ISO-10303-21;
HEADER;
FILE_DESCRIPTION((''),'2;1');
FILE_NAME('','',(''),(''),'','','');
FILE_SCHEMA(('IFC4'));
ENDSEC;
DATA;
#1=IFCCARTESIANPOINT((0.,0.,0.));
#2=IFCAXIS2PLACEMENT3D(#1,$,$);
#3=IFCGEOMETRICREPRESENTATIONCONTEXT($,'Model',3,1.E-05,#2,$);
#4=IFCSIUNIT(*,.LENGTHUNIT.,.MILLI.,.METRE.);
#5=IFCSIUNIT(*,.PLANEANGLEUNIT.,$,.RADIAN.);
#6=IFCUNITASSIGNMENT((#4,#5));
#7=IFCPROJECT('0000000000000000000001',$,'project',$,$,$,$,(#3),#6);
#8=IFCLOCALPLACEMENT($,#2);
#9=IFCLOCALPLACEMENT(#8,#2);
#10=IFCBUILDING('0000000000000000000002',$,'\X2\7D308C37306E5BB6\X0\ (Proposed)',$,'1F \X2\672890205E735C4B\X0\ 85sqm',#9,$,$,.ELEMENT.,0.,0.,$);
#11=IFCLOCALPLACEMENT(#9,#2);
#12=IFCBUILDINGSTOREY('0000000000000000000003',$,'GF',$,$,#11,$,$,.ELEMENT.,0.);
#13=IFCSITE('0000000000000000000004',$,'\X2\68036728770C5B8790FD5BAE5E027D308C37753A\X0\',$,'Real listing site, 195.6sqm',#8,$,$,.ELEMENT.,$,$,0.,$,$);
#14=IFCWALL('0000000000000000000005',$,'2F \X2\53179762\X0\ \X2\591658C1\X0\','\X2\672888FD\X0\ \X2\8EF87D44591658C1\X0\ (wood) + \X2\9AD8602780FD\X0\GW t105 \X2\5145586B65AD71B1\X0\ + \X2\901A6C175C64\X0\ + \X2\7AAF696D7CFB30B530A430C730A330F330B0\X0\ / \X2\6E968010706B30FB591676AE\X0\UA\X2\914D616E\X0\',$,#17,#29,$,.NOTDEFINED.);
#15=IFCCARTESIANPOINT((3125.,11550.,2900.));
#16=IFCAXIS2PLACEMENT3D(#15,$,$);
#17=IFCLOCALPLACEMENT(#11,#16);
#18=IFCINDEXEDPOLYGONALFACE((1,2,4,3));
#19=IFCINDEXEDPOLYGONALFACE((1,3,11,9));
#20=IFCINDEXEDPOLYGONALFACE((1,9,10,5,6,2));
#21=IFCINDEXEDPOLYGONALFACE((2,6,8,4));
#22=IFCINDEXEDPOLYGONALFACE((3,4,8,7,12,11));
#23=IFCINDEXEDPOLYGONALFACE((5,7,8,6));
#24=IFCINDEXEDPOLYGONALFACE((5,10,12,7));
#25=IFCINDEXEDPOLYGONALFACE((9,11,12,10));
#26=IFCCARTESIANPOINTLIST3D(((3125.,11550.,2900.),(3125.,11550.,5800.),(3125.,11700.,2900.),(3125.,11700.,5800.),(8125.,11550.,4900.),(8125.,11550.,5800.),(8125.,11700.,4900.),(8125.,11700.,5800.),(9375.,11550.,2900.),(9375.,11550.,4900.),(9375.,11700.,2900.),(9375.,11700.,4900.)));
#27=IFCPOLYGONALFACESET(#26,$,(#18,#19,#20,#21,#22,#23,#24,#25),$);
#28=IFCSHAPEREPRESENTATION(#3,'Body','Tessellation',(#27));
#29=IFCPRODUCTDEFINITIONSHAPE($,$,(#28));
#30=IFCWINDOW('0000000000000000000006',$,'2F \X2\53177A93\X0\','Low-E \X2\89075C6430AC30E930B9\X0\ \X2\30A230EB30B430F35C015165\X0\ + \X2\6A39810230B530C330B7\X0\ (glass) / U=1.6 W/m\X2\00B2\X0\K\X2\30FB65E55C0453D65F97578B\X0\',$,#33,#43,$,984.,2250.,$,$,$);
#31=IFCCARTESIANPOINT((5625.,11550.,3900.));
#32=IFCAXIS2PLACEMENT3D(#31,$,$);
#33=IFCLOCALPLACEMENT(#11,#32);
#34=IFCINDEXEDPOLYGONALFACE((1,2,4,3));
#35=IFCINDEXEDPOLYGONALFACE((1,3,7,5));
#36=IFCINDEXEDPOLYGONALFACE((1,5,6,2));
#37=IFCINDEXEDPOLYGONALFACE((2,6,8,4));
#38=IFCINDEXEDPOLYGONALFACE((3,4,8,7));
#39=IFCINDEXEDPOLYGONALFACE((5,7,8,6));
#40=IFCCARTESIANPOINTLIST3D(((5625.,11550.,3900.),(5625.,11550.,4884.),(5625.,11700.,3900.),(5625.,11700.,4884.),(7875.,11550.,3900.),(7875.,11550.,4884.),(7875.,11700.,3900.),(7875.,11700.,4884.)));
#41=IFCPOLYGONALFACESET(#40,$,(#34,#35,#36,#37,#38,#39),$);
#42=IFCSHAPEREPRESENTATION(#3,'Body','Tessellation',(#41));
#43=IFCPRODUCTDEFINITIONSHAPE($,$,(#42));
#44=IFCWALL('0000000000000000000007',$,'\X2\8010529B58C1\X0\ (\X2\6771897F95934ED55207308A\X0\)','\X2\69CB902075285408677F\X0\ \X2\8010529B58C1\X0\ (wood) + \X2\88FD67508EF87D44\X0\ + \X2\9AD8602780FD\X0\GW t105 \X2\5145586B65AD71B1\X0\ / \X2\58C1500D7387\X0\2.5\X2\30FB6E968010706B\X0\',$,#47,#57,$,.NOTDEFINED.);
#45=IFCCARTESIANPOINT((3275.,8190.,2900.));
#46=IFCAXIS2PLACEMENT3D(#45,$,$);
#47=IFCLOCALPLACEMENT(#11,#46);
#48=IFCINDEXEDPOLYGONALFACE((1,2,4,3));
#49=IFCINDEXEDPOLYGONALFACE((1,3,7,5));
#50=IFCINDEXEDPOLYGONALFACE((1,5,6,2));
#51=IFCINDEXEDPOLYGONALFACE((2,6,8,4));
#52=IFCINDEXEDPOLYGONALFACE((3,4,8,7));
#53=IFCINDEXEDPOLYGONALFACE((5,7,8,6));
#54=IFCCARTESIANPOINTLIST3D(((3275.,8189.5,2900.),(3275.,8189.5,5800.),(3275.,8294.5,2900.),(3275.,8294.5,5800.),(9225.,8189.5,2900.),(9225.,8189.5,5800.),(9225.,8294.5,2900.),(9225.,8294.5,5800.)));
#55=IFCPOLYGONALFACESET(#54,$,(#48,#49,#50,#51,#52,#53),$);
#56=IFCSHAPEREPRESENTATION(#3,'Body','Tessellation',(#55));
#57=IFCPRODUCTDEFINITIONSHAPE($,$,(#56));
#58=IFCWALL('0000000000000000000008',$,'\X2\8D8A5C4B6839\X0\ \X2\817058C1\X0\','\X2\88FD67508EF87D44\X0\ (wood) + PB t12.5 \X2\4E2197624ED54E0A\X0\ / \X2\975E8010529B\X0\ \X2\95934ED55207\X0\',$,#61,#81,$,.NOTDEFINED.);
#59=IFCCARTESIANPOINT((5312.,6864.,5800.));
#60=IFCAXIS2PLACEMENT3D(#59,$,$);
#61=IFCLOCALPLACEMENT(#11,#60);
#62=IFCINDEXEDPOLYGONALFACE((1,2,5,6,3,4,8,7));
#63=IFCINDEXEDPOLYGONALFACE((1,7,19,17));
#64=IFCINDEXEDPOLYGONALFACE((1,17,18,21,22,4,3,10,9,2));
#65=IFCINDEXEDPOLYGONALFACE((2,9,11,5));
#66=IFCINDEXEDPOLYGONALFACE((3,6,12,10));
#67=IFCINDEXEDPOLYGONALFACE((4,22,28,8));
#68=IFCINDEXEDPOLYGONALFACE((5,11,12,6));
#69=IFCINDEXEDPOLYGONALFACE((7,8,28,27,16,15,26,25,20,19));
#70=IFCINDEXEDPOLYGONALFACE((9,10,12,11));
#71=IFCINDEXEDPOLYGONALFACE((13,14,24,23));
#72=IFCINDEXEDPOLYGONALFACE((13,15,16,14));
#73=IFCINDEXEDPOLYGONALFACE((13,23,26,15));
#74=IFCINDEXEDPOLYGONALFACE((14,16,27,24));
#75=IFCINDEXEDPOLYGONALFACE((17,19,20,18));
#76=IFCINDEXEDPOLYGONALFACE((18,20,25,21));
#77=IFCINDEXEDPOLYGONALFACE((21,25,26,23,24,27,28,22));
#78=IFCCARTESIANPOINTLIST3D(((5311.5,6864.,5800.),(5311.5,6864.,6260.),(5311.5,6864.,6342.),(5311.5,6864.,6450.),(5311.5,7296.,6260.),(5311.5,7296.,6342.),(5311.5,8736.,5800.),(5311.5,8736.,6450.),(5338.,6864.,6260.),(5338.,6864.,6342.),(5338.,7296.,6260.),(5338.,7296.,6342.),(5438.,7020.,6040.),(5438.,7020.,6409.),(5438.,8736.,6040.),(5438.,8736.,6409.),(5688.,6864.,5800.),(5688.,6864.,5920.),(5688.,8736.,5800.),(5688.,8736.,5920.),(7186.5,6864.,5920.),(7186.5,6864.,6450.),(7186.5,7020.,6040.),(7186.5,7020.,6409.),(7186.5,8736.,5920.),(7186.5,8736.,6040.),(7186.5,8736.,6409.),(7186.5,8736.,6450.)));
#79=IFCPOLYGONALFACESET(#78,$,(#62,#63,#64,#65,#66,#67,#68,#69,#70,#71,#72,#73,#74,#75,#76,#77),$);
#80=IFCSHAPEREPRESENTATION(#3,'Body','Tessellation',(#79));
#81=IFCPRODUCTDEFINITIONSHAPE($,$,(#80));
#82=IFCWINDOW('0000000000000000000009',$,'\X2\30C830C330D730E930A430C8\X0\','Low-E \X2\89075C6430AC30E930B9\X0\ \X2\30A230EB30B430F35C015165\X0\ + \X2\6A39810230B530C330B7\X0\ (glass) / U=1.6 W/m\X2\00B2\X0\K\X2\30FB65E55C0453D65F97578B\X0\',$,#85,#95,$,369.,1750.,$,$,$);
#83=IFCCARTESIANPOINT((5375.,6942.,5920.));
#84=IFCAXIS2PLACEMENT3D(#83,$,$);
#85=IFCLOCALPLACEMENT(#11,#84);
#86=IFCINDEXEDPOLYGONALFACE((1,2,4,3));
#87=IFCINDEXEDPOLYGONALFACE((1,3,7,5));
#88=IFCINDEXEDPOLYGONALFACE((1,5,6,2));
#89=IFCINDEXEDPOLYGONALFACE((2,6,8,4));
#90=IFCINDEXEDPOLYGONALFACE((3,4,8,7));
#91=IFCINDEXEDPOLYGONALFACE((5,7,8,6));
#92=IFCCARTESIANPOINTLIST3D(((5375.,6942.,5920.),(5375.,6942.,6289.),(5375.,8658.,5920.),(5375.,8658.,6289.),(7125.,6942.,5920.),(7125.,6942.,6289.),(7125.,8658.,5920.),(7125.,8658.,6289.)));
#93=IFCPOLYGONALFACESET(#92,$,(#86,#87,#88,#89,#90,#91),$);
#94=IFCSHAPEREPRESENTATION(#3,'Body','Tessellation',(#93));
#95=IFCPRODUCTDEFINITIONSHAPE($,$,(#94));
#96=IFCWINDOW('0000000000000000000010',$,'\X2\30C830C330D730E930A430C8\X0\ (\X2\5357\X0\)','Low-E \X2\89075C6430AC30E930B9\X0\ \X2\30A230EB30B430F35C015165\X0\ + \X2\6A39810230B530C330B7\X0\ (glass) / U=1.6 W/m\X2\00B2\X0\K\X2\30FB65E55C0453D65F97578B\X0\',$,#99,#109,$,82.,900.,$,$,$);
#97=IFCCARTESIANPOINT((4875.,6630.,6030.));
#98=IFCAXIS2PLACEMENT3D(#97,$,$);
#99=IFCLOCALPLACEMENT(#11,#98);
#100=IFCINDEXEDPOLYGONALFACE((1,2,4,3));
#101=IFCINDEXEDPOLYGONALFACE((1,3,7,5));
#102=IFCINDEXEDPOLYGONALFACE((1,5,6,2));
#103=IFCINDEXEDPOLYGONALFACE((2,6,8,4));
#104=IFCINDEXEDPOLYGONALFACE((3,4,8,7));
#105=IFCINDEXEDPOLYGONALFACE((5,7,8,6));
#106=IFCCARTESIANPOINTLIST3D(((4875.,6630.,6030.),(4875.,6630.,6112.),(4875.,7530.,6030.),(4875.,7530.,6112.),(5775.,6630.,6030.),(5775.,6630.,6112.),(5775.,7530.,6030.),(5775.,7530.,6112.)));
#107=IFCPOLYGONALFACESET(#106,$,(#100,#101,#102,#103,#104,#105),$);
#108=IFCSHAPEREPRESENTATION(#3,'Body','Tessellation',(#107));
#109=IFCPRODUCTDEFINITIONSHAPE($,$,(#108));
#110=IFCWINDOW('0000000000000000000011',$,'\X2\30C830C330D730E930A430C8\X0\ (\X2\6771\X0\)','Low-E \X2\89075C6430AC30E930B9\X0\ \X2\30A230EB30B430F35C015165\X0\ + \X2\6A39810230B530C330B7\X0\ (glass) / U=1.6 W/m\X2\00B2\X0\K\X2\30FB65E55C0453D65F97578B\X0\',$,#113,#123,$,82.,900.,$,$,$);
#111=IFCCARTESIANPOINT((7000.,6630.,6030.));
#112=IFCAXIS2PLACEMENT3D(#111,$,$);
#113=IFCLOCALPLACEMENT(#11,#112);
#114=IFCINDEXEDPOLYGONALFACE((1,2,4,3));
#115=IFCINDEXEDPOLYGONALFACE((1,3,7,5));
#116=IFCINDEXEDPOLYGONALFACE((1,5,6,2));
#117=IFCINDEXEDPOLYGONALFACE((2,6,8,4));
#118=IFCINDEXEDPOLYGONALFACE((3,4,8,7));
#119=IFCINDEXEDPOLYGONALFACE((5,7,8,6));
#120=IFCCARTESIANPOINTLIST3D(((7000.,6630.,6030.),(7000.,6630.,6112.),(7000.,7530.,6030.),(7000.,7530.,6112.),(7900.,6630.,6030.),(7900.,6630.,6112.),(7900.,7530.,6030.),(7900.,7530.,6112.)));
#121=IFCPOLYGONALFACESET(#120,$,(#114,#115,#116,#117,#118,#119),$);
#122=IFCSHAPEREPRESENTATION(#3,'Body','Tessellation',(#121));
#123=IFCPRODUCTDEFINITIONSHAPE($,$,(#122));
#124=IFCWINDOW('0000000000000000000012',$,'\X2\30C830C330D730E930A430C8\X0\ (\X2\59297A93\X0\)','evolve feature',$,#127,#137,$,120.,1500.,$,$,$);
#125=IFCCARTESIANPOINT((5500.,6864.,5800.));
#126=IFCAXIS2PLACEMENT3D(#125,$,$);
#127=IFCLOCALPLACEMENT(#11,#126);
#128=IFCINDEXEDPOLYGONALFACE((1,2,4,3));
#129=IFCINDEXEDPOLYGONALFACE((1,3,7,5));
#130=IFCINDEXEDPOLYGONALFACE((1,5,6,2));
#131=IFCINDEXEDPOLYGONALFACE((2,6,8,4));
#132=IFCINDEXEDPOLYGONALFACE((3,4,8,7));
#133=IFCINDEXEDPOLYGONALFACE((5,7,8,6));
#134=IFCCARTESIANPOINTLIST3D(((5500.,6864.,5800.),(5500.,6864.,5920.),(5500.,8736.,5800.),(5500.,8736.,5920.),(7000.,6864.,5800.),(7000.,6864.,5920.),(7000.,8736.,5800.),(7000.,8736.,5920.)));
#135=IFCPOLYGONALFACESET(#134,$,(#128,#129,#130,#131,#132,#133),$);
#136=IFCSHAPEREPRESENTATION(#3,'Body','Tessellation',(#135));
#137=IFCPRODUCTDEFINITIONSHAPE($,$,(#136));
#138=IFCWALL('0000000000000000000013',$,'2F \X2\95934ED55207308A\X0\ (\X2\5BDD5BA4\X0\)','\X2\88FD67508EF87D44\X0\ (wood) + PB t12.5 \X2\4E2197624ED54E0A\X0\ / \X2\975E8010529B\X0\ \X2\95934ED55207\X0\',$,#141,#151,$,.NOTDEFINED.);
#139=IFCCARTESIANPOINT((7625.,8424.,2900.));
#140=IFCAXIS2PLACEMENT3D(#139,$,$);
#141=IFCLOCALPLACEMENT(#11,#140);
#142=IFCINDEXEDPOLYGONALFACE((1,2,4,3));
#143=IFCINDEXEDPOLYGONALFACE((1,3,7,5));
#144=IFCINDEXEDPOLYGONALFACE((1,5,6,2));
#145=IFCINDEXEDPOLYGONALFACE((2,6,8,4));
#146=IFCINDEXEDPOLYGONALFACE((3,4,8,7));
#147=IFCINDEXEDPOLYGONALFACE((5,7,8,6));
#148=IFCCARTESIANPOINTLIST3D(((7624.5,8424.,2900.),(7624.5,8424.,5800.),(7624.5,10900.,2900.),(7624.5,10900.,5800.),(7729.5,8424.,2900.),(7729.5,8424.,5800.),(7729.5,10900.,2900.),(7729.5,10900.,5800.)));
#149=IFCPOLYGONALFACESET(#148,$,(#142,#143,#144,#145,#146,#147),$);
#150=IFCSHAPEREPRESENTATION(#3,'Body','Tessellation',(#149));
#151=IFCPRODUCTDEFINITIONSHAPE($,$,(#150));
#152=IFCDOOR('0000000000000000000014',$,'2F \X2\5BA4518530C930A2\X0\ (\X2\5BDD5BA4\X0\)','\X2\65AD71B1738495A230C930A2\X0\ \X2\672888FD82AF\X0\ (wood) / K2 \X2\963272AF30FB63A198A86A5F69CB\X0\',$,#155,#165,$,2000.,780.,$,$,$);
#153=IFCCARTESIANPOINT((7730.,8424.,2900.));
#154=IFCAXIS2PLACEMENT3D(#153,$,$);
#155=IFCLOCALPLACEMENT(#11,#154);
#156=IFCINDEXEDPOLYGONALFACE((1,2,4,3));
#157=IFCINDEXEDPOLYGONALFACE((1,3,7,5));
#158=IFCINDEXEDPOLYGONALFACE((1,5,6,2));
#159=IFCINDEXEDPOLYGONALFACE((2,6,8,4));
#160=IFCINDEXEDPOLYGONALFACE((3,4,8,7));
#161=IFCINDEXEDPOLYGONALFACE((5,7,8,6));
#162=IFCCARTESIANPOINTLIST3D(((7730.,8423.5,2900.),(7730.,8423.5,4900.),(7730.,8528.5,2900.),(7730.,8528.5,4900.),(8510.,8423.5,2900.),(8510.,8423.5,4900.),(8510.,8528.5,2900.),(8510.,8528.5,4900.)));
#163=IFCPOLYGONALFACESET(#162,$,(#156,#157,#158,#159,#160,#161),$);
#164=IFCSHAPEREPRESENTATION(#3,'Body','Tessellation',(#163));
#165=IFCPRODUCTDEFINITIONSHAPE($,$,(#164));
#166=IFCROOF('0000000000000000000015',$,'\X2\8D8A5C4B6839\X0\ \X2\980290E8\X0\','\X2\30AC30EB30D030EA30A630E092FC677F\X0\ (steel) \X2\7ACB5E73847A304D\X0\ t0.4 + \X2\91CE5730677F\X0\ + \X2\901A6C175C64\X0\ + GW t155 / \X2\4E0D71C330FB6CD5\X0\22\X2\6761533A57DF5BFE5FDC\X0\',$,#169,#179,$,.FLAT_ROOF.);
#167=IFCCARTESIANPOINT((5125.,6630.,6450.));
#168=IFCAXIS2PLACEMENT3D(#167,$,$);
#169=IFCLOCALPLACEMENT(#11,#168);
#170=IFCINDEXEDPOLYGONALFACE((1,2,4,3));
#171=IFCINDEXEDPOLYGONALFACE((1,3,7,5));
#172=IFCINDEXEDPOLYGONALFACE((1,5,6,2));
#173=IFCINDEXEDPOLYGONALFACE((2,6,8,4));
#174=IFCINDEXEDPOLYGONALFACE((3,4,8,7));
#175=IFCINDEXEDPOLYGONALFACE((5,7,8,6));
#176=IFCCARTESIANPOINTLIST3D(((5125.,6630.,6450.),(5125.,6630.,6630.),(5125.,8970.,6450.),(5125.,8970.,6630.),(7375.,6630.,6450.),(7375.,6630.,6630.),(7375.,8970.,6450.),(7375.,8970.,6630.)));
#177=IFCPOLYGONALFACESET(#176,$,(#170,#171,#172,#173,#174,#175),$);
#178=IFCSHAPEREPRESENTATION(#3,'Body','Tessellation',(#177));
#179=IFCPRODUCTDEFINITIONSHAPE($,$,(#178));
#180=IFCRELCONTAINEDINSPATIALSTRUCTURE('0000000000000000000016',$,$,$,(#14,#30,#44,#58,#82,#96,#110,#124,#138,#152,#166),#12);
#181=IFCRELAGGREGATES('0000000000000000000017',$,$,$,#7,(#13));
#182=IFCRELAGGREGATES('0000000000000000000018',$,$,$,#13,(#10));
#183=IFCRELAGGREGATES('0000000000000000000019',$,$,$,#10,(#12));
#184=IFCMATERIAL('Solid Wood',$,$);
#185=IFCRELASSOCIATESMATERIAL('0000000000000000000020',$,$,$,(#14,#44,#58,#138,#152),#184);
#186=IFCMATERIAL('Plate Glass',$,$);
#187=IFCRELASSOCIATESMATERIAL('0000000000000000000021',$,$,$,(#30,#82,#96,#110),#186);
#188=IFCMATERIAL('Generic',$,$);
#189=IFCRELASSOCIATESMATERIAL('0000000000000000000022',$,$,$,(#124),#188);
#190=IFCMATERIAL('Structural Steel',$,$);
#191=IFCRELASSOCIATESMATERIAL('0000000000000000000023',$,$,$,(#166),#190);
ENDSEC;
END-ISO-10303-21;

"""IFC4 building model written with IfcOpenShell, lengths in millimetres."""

from ifc_helpers import new_model, si_unit, frame, frame_2d, origin, place, context, project, spatial, rectangle, extrude, material, element, fill, save


model = new_model("IFC4")

# Units and contexts
model_context = context("Model", 3, precision=1e-05, world=origin())
ifc_project = project(units=[si_unit("LENGTHUNIT", "METRE", prefix="MILLI"), si_unit("PLANEANGLEUNIT", "RADIAN")], contexts=[model_context])

# Site, building, storey
site_placement = place(None, origin())
site = spatial("IfcSite", under=ifc_project, at=site_placement, Name="栃木県宇都宮市細谷町", ObjectType="Real listing site, 195.6sqm", CompositionType="ELEMENT", RefElevation=0.0)
building_placement = place(site_placement, origin())
building = spatial("IfcBuilding", under=site, at=building_placement, Name="細谷の家 (Proposed)", ObjectType="1F 木造平屋 85sqm", CompositionType="ELEMENT", ElevationOfRefHeight=0.0, ElevationOfTerrain=0.0)
storey_placement = place(building_placement, origin())
storey = spatial("IfcBuildingStorey", under=building, at=storey_placement, Name="GF", CompositionType="ELEMENT", Elevation=0.0)

# Wall, opening, window
ifc_material_1 = material(Name="Solid Wood")
wall_1_placement = place(storey_placement, frame((3125.0, 11550.0, 2900.0)))
wall_1 = element("IfcWall", 1, at=wall_1_placement, inside=storey, material=ifc_material_1, Name="2F 北面 外壁", Description="木製 軸組外壁 (wood) + 高性能GW t105 充填断熱 + 通気層 + 窯業系サイディング / 準耐火・外皮UA配慮", PredefinedType="NOTDEFINED", context=model_context, shape_type="SweptSolid", body=[
    extrude(rectangle(XDim=6250.0, YDim=150.0, at=frame_2d((3125.0, 75.0))), frame((3125.0, 11550.0, 2900.0)), (0.0, 0.0, 1.0), 2900.0),
])
opening_1_placement = place(storey_placement, frame((5625.0, 11550.0, 3900.0)))
opening_1 = element("IfcOpeningElement", 2, at=opening_1_placement, cuts=wall_1, PredefinedType="NOTDEFINED", context=model_context, shape_type="SweptSolid", body=[
    extrude(rectangle(XDim=2250.0, YDim=150.0, at=frame_2d((1125.0, 75.0))), frame((5625.0, 11550.0, 3900.0)), (0.0, 0.0, 1.0), 984.0),
])
ifc_material_2 = material(Name="Plate Glass")
window_1_placement = place(storey_placement, frame((5625.0, 11550.0, 3900.0)))
window_1 = element("IfcWindow", 3, at=window_1_placement, inside=storey, material=ifc_material_2, Name="2F 北窓", Description="Low-E 複層ガラス アルゴン封入 + 樹脂サッシ (glass) / U=1.6 W/m²K・日射取得型", OverallHeight=984.0, OverallWidth=2250.0, context=model_context, shape_type="SweptSolid", body=[
    extrude(rectangle(XDim=2250.0, YDim=150.0, at=frame_2d((1125.0, 75.0))), frame((5625.0, 11550.0, 3900.0)), (0.0, 0.0, 1.0), 984.0),
])
fill(opening_1, window_1)

# Wall
wall_2_placement = place(storey_placement, frame((3275.0, 8190.0, 2900.0)))
element("IfcWall", 4, at=wall_2_placement, inside=storey, material=ifc_material_1, Name="耐力壁 (東西間仕切り)", Description="構造用合板 耐力壁 (wood) + 製材軸組 + 高性能GW t105 充填断熱 / 壁倍率2.5・準耐火", PredefinedType="NOTDEFINED", context=model_context, shape_type="SweptSolid", body=[
    extrude(rectangle(XDim=5950.0, YDim=105.0, at=frame_2d((2975.0, 52.0))), frame((3275.0, 8190.0, 2900.0)), (0.0, 0.0, 1.0), 2900.0),
])

# Wall, openings, windows
wall_3_placement = place(storey_placement, frame((5312.0, 6864.0, 5800.0)))
wall_3 = element("IfcWall", 5, at=wall_3_placement, inside=storey, material=ifc_material_1, Name="越屋根 腰壁", Description="製材軸組 (wood) + PB t12.5 両面仕上 / 非耐力 間仕切", PredefinedType="NOTDEFINED", context=model_context, shape_type="SweptSolid", body=[
    extrude(rectangle(XDim=1875.0, YDim=1872.0, at=frame_2d((937.0, 936.0))), frame((5312.0, 6864.0, 5800.0)), (0.0, 0.0, 1.0), 650.0),
])
opening_2_placement = place(storey_placement, frame((5375.0, 6942.0, 5920.0)))
opening_2 = element("IfcOpeningElement", 6, at=opening_2_placement, cuts=wall_3, PredefinedType="NOTDEFINED", context=model_context, shape_type="SweptSolid", body=[
    extrude(rectangle(XDim=1750.0, YDim=1716.0, at=frame_2d((875.0, 858.0))), frame((5375.0, 6942.0, 5920.0)), (0.0, 0.0, 1.0), 369.0),
])
opening_3_placement = place(storey_placement, frame((4875.0, 6630.0, 6030.0)))
opening_3 = element("IfcOpeningElement", 7, at=opening_3_placement, cuts=wall_3, PredefinedType="NOTDEFINED", context=model_context, shape_type="SweptSolid", body=[
    extrude(rectangle(XDim=900.0, YDim=900.0, at=frame_2d((450.0, 450.0))), frame((4875.0, 6630.0, 6030.0)), (0.0, 0.0, 1.0), 82.0),
])
opening_4_placement = place(storey_placement, frame((7000.0, 6630.0, 6030.0)))
opening_4 = element("IfcOpeningElement", 8, at=opening_4_placement, cuts=wall_3, PredefinedType="NOTDEFINED", context=model_context, shape_type="SweptSolid", body=[
    extrude(rectangle(XDim=900.0, YDim=900.0, at=frame_2d((450.0, 450.0))), frame((7000.0, 6630.0, 6030.0)), (0.0, 0.0, 1.0), 82.0),
])
opening_5_placement = place(storey_placement, frame((5500.0, 6864.0, 5800.0)))
opening_5 = element("IfcOpeningElement", 9, at=opening_5_placement, cuts=wall_3, PredefinedType="NOTDEFINED", context=model_context, shape_type="SweptSolid", body=[
    extrude(rectangle(XDim=1500.0, YDim=1872.0, at=frame_2d((750.0, 936.0))), frame((5500.0, 6864.0, 5800.0)), (0.0, 0.0, 1.0), 120.0),
])
window_2_placement = place(storey_placement, frame((5375.0, 6942.0, 5920.0)))
window_2 = element("IfcWindow", 10, at=window_2_placement, inside=storey, material=ifc_material_2, Name="トップライト", Description="Low-E 複層ガラス アルゴン封入 + 樹脂サッシ (glass) / U=1.6 W/m²K・日射取得型", OverallHeight=369.0, OverallWidth=1750.0, context=model_context, shape_type="SweptSolid", body=[
    extrude(rectangle(XDim=1750.0, YDim=1716.0, at=frame_2d((875.0, 858.0))), frame((5375.0, 6942.0, 5920.0)), (0.0, 0.0, 1.0), 369.0),
])
fill(opening_2, window_2)
window_3_placement = place(storey_placement, frame((4875.0, 6630.0, 6030.0)))
window_3 = element("IfcWindow", 11, at=window_3_placement, inside=storey, material=ifc_material_2, Name="トップライト (南)", Description="Low-E 複層ガラス アルゴン封入 + 樹脂サッシ (glass) / U=1.6 W/m²K・日射取得型", OverallHeight=82.0, OverallWidth=900.0, context=model_context, shape_type="SweptSolid", body=[
    extrude(rectangle(XDim=900.0, YDim=900.0, at=frame_2d((450.0, 450.0))), frame((4875.0, 6630.0, 6030.0)), (0.0, 0.0, 1.0), 82.0),
])
fill(opening_3, window_3)
window_4_placement = place(storey_placement, frame((7000.0, 6630.0, 6030.0)))
window_4 = element("IfcWindow", 12, at=window_4_placement, inside=storey, material=ifc_material_2, Name="トップライト (東)", Description="Low-E 複層ガラス アルゴン封入 + 樹脂サッシ (glass) / U=1.6 W/m²K・日射取得型", OverallHeight=82.0, OverallWidth=900.0, context=model_context, shape_type="SweptSolid", body=[
    extrude(rectangle(XDim=900.0, YDim=900.0, at=frame_2d((450.0, 450.0))), frame((7000.0, 6630.0, 6030.0)), (0.0, 0.0, 1.0), 82.0),
])
fill(opening_4, window_4)
ifc_material_3 = material(Name="Generic")
window_5_placement = place(storey_placement, frame((5500.0, 6864.0, 5800.0)))
window_5 = element("IfcWindow", 13, at=window_5_placement, inside=storey, material=ifc_material_3, Name="トップライト (天窓)", Description="evolve feature", OverallHeight=120.0, OverallWidth=1500.0, context=model_context, shape_type="SweptSolid", body=[
    extrude(rectangle(XDim=1500.0, YDim=1872.0, at=frame_2d((750.0, 936.0))), frame((5500.0, 6864.0, 5800.0)), (0.0, 0.0, 1.0), 120.0),
])
fill(opening_5, window_5)

# Wall
wall_4_placement = place(storey_placement, frame((7625.0, 8424.0, 2900.0)))
element("IfcWall", 14, at=wall_4_placement, inside=storey, material=ifc_material_1, Name="2F 間仕切り (寝室)", Description="製材軸組 (wood) + PB t12.5 両面仕上 / 非耐力 間仕切", PredefinedType="NOTDEFINED", context=model_context, shape_type="SweptSolid", body=[
    extrude(rectangle(XDim=105.0, YDim=2476.0, at=frame_2d((52.0, 1238.0))), frame((7625.0, 8424.0, 2900.0)), (0.0, 0.0, 1.0), 2900.0),
])

# Door
door_placement = place(storey_placement, frame((7730.0, 8424.0, 2900.0)))
element("IfcDoor", 15, at=door_placement, inside=storey, material=ifc_material_1, Name="2F 室内ドア (寝室)", Description="断熱玄関ドア 木製芯 (wood) / K2 防犯・採風機構", OverallHeight=2000.0, OverallWidth=780.0, context=model_context, shape_type="SweptSolid", body=[
    extrude(rectangle(XDim=780.0, YDim=105.0, at=frame_2d((390.0, 52.0))), frame((7730.0, 8424.0, 2900.0)), (0.0, 0.0, 1.0), 2000.0),
])

# Roof
ifc_material_4 = material(Name="Structural Steel")
roof_placement = place(storey_placement, frame((5125.0, 6630.0, 6450.0)))
element("IfcRoof", 16, at=roof_placement, inside=storey, material=ifc_material_4, Name="越屋根 頂部", Description="ガルバリウム鋼板 (steel) 立平葺き t0.4 + 野地板 + 通気層 + GW t155 / 不燃・法22条区域対応", PredefinedType="FLAT_ROOF", context=model_context, shape_type="SweptSolid", body=[
    extrude(rectangle(XDim=2250.0, YDim=2340.0, at=frame_2d((1125.0, 1170.0))), frame((5125.0, 6630.0, 6450.0)), (0.0, 0.0, 1.0), 180.0),
])

save(model, "model.ifc")
